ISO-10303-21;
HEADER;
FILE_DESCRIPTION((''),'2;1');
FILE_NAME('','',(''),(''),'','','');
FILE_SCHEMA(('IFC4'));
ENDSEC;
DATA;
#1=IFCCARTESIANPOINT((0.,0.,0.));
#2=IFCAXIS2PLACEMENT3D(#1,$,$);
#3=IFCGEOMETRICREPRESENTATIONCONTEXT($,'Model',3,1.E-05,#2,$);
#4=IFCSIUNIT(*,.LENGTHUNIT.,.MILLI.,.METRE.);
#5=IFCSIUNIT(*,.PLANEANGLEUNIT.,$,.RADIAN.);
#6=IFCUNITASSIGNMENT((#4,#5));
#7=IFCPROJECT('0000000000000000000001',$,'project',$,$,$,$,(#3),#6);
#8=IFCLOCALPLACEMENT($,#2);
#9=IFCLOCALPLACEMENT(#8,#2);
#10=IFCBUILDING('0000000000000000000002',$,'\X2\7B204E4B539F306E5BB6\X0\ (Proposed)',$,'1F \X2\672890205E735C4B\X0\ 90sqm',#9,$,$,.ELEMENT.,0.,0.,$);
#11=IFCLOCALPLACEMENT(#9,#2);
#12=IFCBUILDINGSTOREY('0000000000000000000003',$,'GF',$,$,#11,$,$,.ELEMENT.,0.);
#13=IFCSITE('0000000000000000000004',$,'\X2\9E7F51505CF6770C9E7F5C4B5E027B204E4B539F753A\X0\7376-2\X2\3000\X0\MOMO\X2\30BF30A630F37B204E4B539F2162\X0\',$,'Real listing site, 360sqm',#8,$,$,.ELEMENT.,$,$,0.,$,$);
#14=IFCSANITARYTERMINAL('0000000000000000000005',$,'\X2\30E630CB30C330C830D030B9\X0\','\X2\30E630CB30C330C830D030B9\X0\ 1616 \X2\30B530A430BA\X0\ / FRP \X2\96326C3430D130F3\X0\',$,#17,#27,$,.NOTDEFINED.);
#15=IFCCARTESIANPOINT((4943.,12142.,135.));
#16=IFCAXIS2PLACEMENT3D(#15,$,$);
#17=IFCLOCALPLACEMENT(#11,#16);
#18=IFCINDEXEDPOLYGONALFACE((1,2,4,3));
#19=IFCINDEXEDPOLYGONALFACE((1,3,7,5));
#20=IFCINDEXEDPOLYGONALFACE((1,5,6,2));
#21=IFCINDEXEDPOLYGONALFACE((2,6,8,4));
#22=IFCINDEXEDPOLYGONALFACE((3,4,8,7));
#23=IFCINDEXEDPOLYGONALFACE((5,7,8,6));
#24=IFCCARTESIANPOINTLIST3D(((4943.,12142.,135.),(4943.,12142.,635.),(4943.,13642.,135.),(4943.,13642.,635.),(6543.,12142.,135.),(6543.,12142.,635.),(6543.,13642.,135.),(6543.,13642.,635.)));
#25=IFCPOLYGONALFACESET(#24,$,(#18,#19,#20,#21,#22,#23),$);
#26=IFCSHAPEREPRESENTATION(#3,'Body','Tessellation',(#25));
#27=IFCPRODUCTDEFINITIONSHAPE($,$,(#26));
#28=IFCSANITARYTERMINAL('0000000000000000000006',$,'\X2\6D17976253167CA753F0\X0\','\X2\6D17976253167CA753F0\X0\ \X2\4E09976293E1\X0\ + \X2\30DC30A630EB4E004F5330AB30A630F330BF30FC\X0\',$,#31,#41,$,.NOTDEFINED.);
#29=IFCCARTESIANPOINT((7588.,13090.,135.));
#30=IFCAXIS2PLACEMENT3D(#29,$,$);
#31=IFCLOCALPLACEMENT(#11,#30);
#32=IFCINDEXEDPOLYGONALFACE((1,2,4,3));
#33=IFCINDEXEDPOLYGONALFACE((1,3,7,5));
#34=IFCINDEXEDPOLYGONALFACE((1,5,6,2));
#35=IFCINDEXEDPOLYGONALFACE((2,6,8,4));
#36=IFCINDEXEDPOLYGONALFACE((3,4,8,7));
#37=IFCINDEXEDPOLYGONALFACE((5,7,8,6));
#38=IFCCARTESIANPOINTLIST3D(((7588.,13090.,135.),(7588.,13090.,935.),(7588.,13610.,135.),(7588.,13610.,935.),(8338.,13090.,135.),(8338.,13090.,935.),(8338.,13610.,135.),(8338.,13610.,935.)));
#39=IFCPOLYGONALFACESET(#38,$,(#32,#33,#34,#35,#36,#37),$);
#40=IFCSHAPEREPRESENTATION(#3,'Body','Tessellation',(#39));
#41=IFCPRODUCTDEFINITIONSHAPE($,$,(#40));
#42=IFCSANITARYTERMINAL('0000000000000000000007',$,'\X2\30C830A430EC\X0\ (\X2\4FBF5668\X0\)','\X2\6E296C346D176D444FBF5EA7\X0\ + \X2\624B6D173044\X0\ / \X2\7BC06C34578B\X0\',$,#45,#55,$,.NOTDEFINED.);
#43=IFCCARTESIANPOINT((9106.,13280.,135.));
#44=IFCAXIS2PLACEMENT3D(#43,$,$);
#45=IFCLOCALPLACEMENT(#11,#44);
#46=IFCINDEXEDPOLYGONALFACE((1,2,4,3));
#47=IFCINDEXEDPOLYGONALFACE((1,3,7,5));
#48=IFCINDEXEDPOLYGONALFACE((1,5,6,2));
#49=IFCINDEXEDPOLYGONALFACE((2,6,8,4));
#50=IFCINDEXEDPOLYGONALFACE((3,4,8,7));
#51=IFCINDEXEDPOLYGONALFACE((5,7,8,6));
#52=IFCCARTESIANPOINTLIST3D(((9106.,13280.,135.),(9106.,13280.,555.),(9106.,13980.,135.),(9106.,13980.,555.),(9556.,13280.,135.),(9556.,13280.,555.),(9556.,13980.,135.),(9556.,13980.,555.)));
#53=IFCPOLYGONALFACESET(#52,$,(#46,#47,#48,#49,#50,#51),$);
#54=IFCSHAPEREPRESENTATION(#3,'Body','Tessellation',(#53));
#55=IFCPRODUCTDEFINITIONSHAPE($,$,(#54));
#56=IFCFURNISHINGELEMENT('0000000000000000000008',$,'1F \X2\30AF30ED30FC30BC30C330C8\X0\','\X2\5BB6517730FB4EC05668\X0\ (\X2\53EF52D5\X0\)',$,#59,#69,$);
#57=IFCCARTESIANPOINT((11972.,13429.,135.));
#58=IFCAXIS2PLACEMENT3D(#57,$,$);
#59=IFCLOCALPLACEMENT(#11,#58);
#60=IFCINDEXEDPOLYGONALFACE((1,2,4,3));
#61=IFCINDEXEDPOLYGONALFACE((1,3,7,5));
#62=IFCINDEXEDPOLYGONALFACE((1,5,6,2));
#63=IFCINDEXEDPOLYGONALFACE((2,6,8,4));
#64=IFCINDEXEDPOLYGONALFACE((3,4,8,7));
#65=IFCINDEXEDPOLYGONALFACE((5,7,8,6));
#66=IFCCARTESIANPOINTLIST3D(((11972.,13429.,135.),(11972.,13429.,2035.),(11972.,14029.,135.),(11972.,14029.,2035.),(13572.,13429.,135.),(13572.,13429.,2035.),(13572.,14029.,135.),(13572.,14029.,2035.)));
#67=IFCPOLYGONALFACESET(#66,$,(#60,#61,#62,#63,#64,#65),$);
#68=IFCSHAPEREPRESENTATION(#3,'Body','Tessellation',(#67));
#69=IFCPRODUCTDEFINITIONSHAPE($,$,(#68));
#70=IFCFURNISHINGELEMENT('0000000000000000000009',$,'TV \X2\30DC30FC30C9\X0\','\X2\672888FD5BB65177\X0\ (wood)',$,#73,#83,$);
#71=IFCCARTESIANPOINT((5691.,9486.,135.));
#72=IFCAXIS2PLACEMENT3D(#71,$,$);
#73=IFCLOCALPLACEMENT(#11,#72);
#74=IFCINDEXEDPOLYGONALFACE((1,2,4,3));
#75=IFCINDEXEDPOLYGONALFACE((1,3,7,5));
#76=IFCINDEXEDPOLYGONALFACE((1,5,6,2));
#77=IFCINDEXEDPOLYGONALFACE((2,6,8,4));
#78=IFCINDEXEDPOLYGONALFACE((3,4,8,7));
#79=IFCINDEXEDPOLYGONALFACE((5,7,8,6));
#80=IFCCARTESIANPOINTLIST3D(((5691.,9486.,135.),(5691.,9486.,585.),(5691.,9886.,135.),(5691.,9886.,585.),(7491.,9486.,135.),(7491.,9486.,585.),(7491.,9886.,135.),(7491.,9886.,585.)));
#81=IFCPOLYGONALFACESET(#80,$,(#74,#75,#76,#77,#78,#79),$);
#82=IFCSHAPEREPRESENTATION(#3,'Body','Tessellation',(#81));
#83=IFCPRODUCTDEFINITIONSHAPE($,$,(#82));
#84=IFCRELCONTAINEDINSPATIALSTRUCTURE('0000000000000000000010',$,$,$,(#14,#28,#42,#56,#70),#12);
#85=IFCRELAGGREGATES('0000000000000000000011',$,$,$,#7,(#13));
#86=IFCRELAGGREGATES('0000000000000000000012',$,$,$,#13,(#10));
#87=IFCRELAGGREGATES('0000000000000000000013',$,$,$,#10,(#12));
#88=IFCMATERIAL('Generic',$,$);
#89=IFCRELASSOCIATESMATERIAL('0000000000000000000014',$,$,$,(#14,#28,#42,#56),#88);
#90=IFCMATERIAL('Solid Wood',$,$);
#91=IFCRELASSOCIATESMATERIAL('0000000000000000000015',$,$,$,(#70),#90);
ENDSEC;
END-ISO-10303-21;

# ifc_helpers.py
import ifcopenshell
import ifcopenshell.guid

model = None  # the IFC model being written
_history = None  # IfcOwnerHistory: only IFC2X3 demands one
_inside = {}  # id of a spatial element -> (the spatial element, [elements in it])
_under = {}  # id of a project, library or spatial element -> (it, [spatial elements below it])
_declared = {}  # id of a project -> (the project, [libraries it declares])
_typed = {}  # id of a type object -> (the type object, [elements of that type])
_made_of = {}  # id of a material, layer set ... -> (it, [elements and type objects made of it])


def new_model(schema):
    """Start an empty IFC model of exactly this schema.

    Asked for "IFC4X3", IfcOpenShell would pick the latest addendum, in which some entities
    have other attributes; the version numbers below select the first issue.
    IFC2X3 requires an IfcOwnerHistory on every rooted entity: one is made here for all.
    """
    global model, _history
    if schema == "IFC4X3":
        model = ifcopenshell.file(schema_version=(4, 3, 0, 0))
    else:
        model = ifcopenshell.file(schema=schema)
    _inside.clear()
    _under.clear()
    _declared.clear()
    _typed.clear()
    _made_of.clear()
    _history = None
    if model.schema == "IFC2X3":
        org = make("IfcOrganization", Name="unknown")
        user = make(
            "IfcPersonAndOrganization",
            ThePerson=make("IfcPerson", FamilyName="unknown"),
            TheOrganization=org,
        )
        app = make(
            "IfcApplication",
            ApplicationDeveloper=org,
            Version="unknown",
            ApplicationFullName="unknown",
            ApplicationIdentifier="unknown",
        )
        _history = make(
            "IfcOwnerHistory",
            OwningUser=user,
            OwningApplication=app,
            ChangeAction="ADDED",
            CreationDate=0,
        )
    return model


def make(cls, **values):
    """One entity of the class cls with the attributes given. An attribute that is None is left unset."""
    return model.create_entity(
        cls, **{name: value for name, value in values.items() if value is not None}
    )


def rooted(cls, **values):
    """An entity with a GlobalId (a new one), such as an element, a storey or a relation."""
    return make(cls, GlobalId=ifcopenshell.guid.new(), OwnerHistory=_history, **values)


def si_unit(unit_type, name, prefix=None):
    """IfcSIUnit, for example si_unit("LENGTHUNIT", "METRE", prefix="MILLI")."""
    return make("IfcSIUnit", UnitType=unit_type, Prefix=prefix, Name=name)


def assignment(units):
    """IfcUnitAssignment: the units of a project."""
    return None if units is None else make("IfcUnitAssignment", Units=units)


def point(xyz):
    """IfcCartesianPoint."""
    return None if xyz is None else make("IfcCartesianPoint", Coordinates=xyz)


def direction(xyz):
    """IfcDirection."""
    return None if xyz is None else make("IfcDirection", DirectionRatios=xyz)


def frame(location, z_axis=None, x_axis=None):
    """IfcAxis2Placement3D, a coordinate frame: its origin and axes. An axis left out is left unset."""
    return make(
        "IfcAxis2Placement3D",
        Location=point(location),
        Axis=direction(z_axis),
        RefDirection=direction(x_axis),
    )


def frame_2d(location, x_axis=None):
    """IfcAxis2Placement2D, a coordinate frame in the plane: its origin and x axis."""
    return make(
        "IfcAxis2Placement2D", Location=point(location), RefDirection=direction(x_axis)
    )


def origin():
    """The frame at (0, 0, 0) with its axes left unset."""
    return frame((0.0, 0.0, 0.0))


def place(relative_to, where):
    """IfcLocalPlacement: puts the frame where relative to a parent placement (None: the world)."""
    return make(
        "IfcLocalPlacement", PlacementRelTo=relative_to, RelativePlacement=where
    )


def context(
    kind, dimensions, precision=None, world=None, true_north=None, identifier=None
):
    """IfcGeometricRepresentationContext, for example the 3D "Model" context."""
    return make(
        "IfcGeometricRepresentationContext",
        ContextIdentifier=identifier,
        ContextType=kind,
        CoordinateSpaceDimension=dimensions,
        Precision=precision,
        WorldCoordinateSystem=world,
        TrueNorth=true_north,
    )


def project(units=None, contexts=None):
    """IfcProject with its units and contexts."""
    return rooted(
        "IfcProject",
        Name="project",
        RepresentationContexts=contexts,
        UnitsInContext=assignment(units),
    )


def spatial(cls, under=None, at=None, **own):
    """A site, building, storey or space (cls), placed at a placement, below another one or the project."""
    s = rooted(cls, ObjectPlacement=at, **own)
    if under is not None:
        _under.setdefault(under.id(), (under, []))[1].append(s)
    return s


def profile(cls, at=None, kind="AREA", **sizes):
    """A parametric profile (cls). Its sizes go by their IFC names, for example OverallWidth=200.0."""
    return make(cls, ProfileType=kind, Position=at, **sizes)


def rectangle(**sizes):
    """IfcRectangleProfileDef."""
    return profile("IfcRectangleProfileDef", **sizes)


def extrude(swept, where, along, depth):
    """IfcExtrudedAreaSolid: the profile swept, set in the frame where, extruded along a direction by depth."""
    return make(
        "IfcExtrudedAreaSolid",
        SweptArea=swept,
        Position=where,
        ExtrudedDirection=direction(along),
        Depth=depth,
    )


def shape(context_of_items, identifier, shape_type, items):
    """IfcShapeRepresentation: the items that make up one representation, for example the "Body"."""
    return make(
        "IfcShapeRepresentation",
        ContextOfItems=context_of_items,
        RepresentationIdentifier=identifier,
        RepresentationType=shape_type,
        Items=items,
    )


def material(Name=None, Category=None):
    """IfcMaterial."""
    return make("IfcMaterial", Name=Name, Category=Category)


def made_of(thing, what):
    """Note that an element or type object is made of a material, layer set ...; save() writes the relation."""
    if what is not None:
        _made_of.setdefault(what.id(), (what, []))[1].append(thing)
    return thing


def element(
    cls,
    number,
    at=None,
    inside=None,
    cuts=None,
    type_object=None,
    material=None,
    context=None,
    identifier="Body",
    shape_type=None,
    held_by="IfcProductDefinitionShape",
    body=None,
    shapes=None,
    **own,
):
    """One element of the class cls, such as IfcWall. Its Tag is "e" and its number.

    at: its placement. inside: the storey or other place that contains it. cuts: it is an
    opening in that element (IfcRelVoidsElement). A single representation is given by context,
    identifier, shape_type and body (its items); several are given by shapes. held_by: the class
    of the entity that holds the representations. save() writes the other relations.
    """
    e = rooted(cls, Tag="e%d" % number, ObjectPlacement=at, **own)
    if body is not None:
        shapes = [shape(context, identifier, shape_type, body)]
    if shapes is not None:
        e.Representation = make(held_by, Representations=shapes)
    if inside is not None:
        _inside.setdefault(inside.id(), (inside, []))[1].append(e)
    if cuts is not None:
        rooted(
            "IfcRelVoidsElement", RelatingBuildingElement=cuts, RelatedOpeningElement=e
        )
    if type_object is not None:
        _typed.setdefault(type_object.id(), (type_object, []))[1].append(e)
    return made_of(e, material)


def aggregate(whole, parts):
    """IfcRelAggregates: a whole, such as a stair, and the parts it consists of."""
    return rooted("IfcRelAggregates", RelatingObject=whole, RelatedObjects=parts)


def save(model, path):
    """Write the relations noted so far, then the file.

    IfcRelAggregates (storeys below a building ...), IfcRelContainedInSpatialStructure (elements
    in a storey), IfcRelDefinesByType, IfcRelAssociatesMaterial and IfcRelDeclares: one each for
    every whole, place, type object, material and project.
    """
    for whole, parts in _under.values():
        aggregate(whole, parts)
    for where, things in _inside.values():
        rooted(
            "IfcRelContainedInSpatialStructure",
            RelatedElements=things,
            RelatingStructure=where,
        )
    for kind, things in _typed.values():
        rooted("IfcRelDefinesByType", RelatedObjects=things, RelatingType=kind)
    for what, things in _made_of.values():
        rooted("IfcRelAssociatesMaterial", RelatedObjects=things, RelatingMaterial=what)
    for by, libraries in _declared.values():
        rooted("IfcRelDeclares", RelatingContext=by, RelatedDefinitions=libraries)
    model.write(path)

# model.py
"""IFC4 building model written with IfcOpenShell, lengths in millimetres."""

from ifc_helpers import new_model, si_unit, frame, frame_2d, origin, place, context, project, spatial, rectangle, extrude, material, element, save


model = new_model("IFC4")

# Units and contexts
model_context = context("Model", 3, precision=1e-05, world=origin())
ifc_project = project(units=[si_unit("LENGTHUNIT", "METRE", prefix="MILLI"), si_unit("PLANEANGLEUNIT", "RADIAN")], contexts=[model_context])

# Site, building, storey
site_placement = place(None, origin())
site = spatial("IfcSite", under=ifc_project, at=site_placement, Name="鹿児島県鹿屋市笠之原町7376-2　MOMOタウン笠之原Ⅲ", ObjectType="Real listing site, 360sqm", CompositionType="ELEMENT", RefElevation=0.0)
building_placement = place(site_placement, origin())
building = spatial("IfcBuilding", under=site, at=building_placement, Name="笠之原の家 (Proposed)", ObjectType="1F 木造平屋 90sqm", CompositionType="ELEMENT", ElevationOfRefHeight=0.0, ElevationOfTerrain=0.0)
storey_placement = place(building_placement, origin())
storey = spatial("IfcBuildingStorey", under=building, at=storey_placement, Name="GF", CompositionType="ELEMENT", Elevation=0.0)

# Shared definitions
ifc_material_1 = material(Name="Solid Wood")

# Sanitary terminals
ifc_material_2 = material(Name="Generic")
sanitary_terminal_1_placement = place(storey_placement, frame((4943.0, 12142.0, 135.0)))
element("IfcSanitaryTerminal", 1, at=sanitary_terminal_1_placement, inside=storey, material=ifc_material_2, Name="ユニットバス", Description="ユニットバス 1616 サイズ / FRP 防水パン", PredefinedType="NOTDEFINED", context=model_context, shape_type="SweptSolid", body=[
    extrude(rectangle(XDim=1600.0, YDim=1500.0, at=frame_2d((800.0, 750.0))), frame((4943.0, 12142.0, 135.0)), (0.0, 0.0, 1.0), 500.0),
])
sanitary_terminal_2_placement = place(storey_placement, frame((7588.0, 13090.0, 135.0)))
element("IfcSanitaryTerminal", 2, at=sanitary_terminal_2_placement, inside=storey, material=ifc_material_2, Name="洗面化粧台", Description="洗面化粧台 三面鏡 + ボウル一体カウンター", PredefinedType="NOTDEFINED", context=model_context, shape_type="SweptSolid", body=[
    extrude(rectangle(XDim=750.0, YDim=520.0, at=frame_2d((375.0, 260.0))), frame((7588.0, 13090.0, 135.0)), (0.0, 0.0, 1.0), 800.0),
])
sanitary_terminal_3_placement = place(storey_placement, frame((9106.0, 13280.0, 135.0)))
element("IfcSanitaryTerminal", 3, at=sanitary_terminal_3_placement, inside=storey, material=ifc_material_2, Name="トイレ (便器)", Description="温水洗浄便座 + 手洗い / 節水型", PredefinedType="NOTDEFINED", context=model_context, shape_type="SweptSolid", body=[
    extrude(rectangle(XDim=450.0, YDim=700.0, at=frame_2d((225.0, 350.0))), frame((9106.0, 13280.0, 135.0)), (0.0, 0.0, 1.0), 420.0),
])

# Furnishing elements
furnishing_1_placement = place(storey_placement, frame((11972.0, 13429.0, 135.0)))
element("IfcFurnishingElement", 4, at=furnishing_1_placement, inside=storey, material=ifc_material_2, Name="1F クローゼット", Description="家具・什器 (可動)", context=model_context, shape_type="SweptSolid", body=[
    extrude(rectangle(XDim=1600.0, YDim=600.0, at=frame_2d((800.0, 300.0))), frame((11972.0, 13429.0, 135.0)), (0.0, 0.0, 1.0), 1900.0),
])
furnishing_2_placement = place(storey_placement, frame((5691.0, 9486.0, 135.0)))
element("IfcFurnishingElement", 5, at=furnishing_2_placement, inside=storey, material=ifc_material_1, Name="TV ボード", Description="木製家具 (wood)", context=model_context, shape_type="SweptSolid", body=[
    extrude(rectangle(XDim=1800.0, YDim=400.0, at=frame_2d((900.0, 200.0))), frame((5691.0, 9486.0, 135.0)), (0.0, 0.0, 1.0), 450.0),
])

save(model, "model.ifc")
